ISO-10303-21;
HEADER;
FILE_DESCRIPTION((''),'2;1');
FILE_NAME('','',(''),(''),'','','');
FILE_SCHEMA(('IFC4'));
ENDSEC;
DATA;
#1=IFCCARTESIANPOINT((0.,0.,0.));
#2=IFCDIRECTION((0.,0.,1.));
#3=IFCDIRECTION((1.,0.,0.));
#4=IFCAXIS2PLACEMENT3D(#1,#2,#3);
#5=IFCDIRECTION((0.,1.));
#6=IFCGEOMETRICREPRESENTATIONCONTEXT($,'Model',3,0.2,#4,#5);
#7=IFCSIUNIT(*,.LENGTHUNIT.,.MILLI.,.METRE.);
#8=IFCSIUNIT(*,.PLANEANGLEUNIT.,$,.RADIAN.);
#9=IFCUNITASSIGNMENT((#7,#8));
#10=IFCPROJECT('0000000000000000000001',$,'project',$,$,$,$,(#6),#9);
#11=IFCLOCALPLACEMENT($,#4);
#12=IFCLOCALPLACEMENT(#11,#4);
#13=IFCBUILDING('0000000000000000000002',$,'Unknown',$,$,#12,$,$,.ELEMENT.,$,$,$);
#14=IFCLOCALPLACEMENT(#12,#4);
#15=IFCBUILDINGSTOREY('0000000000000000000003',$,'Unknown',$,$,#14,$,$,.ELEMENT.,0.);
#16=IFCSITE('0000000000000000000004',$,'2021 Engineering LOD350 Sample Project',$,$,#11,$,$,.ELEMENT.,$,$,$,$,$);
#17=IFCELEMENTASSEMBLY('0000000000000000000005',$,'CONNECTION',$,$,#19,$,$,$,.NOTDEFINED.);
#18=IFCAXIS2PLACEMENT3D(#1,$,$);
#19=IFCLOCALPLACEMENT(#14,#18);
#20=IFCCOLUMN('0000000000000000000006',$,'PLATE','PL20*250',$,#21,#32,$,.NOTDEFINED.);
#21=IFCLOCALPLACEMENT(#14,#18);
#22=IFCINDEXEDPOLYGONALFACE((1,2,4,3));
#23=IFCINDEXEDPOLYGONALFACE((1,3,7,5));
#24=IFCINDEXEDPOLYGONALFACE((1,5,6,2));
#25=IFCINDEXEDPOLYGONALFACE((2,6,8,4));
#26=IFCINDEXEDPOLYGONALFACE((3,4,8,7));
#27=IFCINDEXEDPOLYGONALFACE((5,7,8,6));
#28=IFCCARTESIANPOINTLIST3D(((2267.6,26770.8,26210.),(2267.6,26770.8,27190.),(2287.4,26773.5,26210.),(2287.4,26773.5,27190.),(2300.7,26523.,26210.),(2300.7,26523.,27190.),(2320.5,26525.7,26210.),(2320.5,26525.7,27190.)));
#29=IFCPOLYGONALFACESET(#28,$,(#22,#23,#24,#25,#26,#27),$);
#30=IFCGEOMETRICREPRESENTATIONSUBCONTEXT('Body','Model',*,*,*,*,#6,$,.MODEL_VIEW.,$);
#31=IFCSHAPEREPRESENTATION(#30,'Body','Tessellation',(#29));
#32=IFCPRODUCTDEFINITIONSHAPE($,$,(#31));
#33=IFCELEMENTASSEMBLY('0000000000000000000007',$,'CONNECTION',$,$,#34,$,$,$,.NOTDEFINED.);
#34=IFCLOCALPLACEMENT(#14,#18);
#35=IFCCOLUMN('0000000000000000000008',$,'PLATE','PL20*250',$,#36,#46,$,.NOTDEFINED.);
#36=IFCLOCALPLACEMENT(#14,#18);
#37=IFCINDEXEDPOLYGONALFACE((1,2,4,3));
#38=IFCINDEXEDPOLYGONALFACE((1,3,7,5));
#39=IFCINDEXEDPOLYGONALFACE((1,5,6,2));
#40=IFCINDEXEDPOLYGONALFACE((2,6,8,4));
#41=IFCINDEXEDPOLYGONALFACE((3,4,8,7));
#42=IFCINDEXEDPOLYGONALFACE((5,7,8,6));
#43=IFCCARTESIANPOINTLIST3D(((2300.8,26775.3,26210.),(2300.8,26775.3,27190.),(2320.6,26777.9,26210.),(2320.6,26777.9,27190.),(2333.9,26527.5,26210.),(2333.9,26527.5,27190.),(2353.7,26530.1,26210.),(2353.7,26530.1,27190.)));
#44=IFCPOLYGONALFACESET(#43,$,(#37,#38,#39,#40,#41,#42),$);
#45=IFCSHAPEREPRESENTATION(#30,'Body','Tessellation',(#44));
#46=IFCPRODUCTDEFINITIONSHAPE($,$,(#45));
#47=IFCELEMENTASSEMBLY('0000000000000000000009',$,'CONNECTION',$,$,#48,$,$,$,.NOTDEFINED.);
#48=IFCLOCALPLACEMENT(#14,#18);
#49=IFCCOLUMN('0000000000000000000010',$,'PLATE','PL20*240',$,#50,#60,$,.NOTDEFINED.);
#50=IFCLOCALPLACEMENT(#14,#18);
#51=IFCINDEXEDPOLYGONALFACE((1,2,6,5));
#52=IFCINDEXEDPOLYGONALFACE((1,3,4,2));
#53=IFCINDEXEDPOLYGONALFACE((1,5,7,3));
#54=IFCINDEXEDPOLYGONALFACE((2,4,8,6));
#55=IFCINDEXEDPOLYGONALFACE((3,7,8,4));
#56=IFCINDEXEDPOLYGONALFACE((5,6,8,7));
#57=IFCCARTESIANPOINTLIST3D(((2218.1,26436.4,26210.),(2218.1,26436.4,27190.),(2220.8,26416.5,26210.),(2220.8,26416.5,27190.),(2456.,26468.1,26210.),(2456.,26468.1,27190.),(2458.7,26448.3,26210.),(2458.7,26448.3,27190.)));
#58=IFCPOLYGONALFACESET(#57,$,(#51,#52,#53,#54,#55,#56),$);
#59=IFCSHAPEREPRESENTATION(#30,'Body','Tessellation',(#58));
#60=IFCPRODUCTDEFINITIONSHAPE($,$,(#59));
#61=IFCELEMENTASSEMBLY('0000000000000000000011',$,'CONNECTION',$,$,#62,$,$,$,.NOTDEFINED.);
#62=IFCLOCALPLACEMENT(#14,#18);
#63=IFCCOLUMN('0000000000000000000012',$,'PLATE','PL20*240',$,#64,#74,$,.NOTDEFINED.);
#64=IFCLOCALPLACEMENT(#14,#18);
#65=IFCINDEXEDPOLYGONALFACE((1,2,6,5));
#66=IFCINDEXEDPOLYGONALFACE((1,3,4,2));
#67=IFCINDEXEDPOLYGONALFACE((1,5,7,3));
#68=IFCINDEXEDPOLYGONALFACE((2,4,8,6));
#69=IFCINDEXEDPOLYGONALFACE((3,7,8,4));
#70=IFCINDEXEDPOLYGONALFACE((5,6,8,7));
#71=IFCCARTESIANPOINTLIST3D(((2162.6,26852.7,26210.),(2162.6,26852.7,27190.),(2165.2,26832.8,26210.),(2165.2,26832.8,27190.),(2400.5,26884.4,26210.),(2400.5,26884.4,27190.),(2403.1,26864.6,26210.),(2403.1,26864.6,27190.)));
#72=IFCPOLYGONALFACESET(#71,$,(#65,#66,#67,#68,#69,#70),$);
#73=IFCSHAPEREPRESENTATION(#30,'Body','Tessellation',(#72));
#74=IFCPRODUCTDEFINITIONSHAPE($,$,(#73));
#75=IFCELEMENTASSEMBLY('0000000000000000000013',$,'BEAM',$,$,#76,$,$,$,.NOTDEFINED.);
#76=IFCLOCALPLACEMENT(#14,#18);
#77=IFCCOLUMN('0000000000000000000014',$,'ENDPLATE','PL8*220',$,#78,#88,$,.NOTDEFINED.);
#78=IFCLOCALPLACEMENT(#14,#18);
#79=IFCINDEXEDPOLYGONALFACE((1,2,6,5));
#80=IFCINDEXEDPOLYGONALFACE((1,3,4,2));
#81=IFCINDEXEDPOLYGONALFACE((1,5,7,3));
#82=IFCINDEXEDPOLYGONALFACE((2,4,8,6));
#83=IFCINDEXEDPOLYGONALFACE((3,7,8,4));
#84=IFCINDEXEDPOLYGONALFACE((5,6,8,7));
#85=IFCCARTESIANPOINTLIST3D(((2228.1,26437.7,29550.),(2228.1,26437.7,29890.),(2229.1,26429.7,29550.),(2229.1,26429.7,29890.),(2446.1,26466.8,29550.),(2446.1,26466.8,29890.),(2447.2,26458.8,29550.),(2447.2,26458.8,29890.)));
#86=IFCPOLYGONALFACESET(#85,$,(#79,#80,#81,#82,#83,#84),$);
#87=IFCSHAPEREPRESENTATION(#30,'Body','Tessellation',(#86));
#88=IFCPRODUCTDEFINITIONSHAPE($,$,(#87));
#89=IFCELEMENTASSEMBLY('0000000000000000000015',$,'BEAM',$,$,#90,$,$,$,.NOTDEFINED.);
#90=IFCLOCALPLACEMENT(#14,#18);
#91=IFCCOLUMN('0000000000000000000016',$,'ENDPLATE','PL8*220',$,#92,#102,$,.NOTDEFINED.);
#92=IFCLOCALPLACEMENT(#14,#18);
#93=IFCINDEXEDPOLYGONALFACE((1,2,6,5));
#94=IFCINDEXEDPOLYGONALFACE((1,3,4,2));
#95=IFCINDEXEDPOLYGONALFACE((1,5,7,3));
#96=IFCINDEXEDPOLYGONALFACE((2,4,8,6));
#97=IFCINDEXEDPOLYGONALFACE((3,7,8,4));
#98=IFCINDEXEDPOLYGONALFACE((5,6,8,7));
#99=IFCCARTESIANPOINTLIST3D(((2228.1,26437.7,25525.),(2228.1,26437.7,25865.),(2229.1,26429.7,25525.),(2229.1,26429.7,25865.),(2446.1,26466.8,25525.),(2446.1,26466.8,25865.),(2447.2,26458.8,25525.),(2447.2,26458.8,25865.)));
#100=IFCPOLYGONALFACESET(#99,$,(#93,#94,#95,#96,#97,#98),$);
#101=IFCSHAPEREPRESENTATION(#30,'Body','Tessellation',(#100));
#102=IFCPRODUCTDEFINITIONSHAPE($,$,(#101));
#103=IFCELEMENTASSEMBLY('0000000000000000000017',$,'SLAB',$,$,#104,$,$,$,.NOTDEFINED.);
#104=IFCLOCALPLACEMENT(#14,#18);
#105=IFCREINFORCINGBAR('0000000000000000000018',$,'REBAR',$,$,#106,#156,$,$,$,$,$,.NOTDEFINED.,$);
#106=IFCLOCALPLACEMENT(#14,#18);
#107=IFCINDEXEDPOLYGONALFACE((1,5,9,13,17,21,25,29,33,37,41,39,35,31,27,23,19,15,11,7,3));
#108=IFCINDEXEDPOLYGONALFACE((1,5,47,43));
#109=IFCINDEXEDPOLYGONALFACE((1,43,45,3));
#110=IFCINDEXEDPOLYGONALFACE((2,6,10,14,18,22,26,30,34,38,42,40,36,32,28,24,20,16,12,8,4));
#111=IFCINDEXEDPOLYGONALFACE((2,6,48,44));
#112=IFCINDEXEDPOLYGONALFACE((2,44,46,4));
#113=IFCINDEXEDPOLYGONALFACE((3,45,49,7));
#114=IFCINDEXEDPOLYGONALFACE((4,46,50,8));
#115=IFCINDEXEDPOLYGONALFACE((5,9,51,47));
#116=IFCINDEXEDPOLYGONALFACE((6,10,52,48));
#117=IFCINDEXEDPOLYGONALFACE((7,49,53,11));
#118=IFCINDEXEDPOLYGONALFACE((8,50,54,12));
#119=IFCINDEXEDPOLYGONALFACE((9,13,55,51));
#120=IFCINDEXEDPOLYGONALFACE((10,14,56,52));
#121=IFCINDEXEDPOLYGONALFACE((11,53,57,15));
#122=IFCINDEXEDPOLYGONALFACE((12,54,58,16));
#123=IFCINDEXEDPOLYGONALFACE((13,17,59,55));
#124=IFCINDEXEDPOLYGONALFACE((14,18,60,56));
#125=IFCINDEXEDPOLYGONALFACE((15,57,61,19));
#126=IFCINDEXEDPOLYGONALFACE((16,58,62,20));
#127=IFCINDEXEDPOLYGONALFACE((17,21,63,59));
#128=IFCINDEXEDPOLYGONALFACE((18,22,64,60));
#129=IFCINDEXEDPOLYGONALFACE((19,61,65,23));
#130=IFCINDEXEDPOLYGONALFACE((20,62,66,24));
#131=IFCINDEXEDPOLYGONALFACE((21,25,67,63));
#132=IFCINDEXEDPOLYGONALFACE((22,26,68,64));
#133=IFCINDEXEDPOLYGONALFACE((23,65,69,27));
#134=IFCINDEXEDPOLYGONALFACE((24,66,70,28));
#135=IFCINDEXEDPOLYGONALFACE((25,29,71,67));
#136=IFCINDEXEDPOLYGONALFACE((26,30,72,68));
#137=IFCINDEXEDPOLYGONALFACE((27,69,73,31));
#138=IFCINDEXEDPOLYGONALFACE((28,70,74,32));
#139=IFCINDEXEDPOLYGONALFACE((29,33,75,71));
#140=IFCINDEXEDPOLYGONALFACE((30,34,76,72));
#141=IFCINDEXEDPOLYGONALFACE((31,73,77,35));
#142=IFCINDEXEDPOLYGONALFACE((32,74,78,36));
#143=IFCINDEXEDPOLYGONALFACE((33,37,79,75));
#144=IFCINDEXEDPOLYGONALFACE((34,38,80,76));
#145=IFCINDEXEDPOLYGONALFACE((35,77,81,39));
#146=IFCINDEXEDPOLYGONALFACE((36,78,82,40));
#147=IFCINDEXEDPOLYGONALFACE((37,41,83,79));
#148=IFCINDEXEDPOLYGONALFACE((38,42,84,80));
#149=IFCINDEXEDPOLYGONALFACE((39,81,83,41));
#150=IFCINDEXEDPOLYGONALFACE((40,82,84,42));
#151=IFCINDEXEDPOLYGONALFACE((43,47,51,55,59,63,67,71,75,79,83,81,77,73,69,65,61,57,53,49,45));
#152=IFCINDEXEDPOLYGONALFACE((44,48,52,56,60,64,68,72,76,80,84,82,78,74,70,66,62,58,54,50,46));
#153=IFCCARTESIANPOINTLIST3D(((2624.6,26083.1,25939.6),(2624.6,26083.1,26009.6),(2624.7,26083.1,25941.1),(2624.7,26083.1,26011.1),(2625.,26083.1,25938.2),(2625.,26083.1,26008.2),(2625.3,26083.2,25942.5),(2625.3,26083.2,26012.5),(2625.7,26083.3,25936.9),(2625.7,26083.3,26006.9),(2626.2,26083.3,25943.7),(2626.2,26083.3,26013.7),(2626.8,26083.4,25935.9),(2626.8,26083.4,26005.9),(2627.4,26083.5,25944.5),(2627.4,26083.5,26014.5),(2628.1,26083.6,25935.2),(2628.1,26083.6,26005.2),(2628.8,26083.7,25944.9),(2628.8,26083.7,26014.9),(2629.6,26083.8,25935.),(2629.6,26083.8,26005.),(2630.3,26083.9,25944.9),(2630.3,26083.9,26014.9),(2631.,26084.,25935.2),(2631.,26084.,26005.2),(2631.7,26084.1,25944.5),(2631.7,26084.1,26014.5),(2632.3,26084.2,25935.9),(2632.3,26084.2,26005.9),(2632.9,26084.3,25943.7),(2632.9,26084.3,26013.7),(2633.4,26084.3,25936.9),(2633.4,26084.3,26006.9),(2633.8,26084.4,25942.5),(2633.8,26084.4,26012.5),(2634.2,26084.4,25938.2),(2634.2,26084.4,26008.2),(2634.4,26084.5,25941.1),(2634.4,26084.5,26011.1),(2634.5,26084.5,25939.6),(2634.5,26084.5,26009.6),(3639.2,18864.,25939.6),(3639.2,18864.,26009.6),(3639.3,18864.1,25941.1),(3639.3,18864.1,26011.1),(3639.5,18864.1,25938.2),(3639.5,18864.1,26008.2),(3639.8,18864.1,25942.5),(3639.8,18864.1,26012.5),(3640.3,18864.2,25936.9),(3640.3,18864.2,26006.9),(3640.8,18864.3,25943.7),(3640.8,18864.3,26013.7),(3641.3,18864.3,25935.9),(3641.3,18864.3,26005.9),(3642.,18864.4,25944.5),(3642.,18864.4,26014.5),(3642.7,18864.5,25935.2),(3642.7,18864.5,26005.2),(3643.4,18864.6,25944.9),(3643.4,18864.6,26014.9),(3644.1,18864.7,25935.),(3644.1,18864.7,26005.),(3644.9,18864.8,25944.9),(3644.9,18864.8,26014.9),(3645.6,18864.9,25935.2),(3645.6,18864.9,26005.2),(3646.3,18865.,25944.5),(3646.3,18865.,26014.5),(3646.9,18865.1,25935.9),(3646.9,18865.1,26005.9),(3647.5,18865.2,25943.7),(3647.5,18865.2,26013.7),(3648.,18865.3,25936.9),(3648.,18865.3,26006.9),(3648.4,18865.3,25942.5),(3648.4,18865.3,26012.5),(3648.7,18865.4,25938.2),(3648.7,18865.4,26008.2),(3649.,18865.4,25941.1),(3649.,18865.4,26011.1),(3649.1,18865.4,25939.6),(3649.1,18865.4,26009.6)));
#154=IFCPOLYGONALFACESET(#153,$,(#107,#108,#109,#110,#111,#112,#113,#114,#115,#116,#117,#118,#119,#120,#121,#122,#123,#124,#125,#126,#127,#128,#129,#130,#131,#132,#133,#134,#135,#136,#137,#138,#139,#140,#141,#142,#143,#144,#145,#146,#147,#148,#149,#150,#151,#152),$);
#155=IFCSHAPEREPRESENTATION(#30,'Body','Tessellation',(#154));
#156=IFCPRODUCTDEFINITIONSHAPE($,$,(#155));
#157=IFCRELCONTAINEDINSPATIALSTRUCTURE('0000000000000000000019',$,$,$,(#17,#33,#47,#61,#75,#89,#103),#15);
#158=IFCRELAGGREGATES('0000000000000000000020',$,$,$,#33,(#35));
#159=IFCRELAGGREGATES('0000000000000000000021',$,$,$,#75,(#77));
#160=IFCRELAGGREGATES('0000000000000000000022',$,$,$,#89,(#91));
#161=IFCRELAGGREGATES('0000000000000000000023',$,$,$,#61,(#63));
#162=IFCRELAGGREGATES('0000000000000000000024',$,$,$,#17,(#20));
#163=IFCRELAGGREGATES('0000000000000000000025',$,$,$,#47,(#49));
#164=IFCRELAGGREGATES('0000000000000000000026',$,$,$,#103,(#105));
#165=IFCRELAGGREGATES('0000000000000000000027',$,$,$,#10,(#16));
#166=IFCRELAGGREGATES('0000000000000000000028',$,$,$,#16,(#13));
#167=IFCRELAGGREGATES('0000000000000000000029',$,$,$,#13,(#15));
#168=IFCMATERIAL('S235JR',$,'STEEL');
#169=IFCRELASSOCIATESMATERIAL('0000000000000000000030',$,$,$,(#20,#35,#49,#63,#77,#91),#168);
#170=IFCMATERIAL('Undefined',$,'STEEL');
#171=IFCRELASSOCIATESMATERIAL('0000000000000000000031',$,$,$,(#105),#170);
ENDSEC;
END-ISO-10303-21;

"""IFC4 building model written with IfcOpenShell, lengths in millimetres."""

from ifc_helpers import new_model, entity, si_unit, direction, frame, origin_with_axes, place, context, subcontext, project, spatial, line, indexed_curve, outline, extrude, source, transform, mapped, material, element, aggregate, save


model = new_model("IFC4")

# Units and contexts
model_context = context("Model", 3, precision=0.2, world=origin_with_axes(), true_north=direction((0.0, 1.0)))
body_context = subcontext(model_context, "Body", "Model", "MODEL_VIEW")
ifc_project = project(units=[si_unit("LENGTHUNIT", "METRE", prefix="MILLI"), si_unit("PLANEANGLEUNIT", "RADIAN")], contexts=[model_context])

# Site, building, storey
site_placement = place(None, origin_with_axes())
site = spatial("IfcSite", under=ifc_project, at=site_placement, Name="2021 Engineering LOD350 Sample Project", CompositionType="ELEMENT")
building_placement = place(site_placement, origin_with_axes())
building = spatial("IfcBuilding", under=site, at=building_placement, Name="Unknown", CompositionType="ELEMENT")
storey_placement = place(building_placement, origin_with_axes())
storey = spatial("IfcBuildingStorey", under=building, at=storey_placement, Name="Unknown", CompositionType="ELEMENT", Elevation=0.0)

# Shared definitions
ifc_material_1 = material(Name="S235JR", Category="STEEL")

# Element assemblies, columns
assembly_1_placement = place(storey_placement, frame((2294.0, 26648.3, 26210.0), z_axis=(-0.991216, -0.132256, 0.0), x_axis=(0.0, 0.0, 1.0)))
assembly_1 = element("IfcElementAssembly", 1, at=assembly_1_placement, inside=storey, Name="CONNECTION", PredefinedType="NOTDEFINED")
column_1_placement = place(assembly_1_placement, origin_with_axes())
column_1 = element("IfcColumn", 2, at=column_1_placement, material=ifc_material_1, Name="PLATE", Description="PL20*250", PredefinedType="NOTDEFINED", context=body_context, shape_type="SolidModel", body=[
    extrude(outline(indexed_curve([(-10.0, -125.0), (10.0, -125.0), (10.0, 125.0), (-10.0, 125.0)], segments=[line(1, 2, 3, 4, 1)])), frame((0.0, 0.0, 0.0), z_axis=(-1.0, 0.0, 0.0), x_axis=(0.0, 0.0, 1.0)), (0.0, 0.0, -1.0), 980.0),
])
assembly_2_placement = place(storey_placement, frame((2327.2, 26652.7, 26210.0), z_axis=(-0.991216, -0.132256, 0.0), x_axis=(0.0, 0.0, 1.0)))
assembly_2 = element("IfcElementAssembly", 3, at=assembly_2_placement, inside=storey, Name="CONNECTION", PredefinedType="NOTDEFINED")
column_2_placement = place(assembly_2_placement, origin_with_axes())
column_2 = element("IfcColumn", 4, at=column_2_placement, material=ifc_material_1, Name="PLATE", Description="PL20*250", PredefinedType="NOTDEFINED", context=body_context, shape_type="SolidModel", body=[
    extrude(outline(indexed_curve([(-10.0, -125.0), (10.0, -125.0), (10.0, 125.0), (-10.0, 125.0)], segments=[line(1, 2, 3, 4, 1)])), frame((0.0, 0.0, 0.0), z_axis=(-1.0, 0.0, 0.0), x_axis=(0.0, 0.0, 1.0)), (0.0, 0.0, -1.0), 980.0),
])
aggregate(assembly_2, [column_2])
assembly_3_placement = place(storey_placement, frame((2338.4, 26442.3, 26210.0), z_axis=(0.132256, -0.991216, 0.0), x_axis=(0.0, 0.0, 1.0)))
assembly_3 = element("IfcElementAssembly", 5, at=assembly_3_placement, inside=storey, Name="CONNECTION", PredefinedType="NOTDEFINED")
column_3_placement = place(assembly_3_placement, origin_with_axes())
column_3 = element("IfcColumn", 6, at=column_3_placement, material=ifc_material_1, Name="PLATE", Description="PL20*240", PredefinedType="NOTDEFINED", context=body_context, shape_type="SolidModel", body=[
    extrude(outline(indexed_curve([(-10.0, -120.0), (10.0, -120.0), (10.0, 120.0), (-10.0, 120.0)], segments=[line(1, 2, 3, 4, 1)])), frame((0.0, 0.0, 0.0), z_axis=(-1.0, 0.0, 0.0), x_axis=(0.0, 0.0, 1.0)), (0.0, 0.0, -1.0), 980.0),
])
assembly_4_placement = place(storey_placement, frame((2282.9, 26858.6, 26210.0), z_axis=(-0.132256, 0.991216, 0.0), x_axis=(0.0, 0.0, 1.0)))
assembly_4 = element("IfcElementAssembly", 7, at=assembly_4_placement, inside=storey, Name="CONNECTION", PredefinedType="NOTDEFINED")
column_4_placement = place(assembly_4_placement, origin_with_axes())
column_4 = element("IfcColumn", 8, at=column_4_placement, material=ifc_material_1, Name="PLATE", Description="PL20*240", PredefinedType="NOTDEFINED", context=body_context, shape_type="SolidModel", body=[
    extrude(outline(indexed_curve([(-10.0, -120.0), (10.0, -120.0), (10.0, 120.0), (-10.0, 120.0)], segments=[line(1, 2, 3, 4, 1)])), frame((0.0, 0.0, 0.0), z_axis=(-1.0, 0.0, 0.0), x_axis=(0.0, 0.0, 1.0)), (0.0, 0.0, -1.0), 980.0),
])
assembly_5_placement = place(storey_placement, frame((2462.8, 25510.0, 29720.0), z_axis=(0.991216, 0.132255, 0.0), x_axis=(-0.132255, 0.991216, 0.0)))
assembly_5 = element("IfcElementAssembly", 9, at=assembly_5_placement, inside=storey, Name="BEAM", PredefinedType="NOTDEFINED")
column_5_placement = place(assembly_5_placement, frame((946.6, -170.0, 0.0), z_axis=(-1.0, 0.0, 0.000001), x_axis=(0.0, 1.0, 0.0)))
column_5 = element("IfcColumn", 10, at=column_5_placement, material=ifc_material_1, Name="ENDPLATE", Description="PL8*220", PredefinedType="NOTDEFINED", context=body_context, shape_type="SolidModel", body=[
    extrude(outline(indexed_curve([(-4.0, -110.0), (4.0, -110.0), (4.0, 110.0), (-4.0, 110.0)], segments=[line(1, 2, 3, 4, 1)])), frame((0.0, 0.0, 0.0), z_axis=(-1.0, 0.0, 0.0), x_axis=(0.0, 0.0, 1.0)), (0.0, 0.0, -1.0), 340.0),
])
aggregate(assembly_5, [column_5])
assembly_6_placement = place(storey_placement, frame((2462.8, 25510.0, 25695.0), z_axis=(0.991216, 0.132255, 0.0), x_axis=(-0.132255, 0.991216, 0.0)))
assembly_6 = element("IfcElementAssembly", 11, at=assembly_6_placement, inside=storey, Name="BEAM", PredefinedType="NOTDEFINED")
column_6_placement = place(assembly_6_placement, frame((946.6, -170.0, 0.0), z_axis=(-1.0, 0.0, 0.000001), x_axis=(0.0, 1.0, 0.0)))
column_6 = element("IfcColumn", 12, at=column_6_placement, material=ifc_material_1, Name="ENDPLATE", Description="PL8*220", PredefinedType="NOTDEFINED", context=body_context, shape_type="SolidModel", body=[
    extrude(outline(indexed_curve([(-4.0, -110.0), (4.0, -110.0), (4.0, 110.0), (-4.0, 110.0)], segments=[line(1, 2, 3, 4, 1)])), frame((0.0, 0.0, 0.0), z_axis=(-1.0, 0.0, 0.0), x_axis=(0.0, 0.0, 1.0)), (0.0, 0.0, -1.0), 340.0),
])

aggregate(assembly_6, [column_6])

# Element assembly, reinforcing bar
assembly_7_placement = place(storey_placement, frame((0.0, 19194.4, 25975.0), z_axis=(0.0, 0.0, 1.0), x_axis=(0.0, -1.0, 0.0)))
assembly_7 = element("IfcElementAssembly", 13, at=assembly_7_placement, inside=storey, Name="SLAB", PredefinedType="NOTDEFINED")
ifc_material_2 = material(Name="Undefined", Category="STEEL")
shared_shape_1 = source(origin_with_axes(), body_context, "Body", "AdvancedSweptSolid", [
    entity("IfcSweptDiskSolid", entity("IfcIndexedPolyCurve", entity("IfcCartesianPointList3D", [[0.0, 0.0, 0.0], [7290.0, 0.0, 0.0]]), [entity("IfcLineIndex", [1, 2])]), 5.0),
])
reinforcing_bar_1_placement = place(assembly_7_placement, frame((-6889.4, 2629.6, -35.0), z_axis=(0.0, 0.0, -1.0), x_axis=(0.990268, 0.139173, 0.0)))
reinforcing_bar_1 = element("IfcReinforcingBar", 14, at=reinforcing_bar_1_placement, material=ifc_material_2, Name="REBAR", PredefinedType="NOTDEFINED", context=body_context, shape_type="MappedRepresentation", body=[
    mapped(shared_shape_1, transform((0.0, 0.0, 0.0))),
    mapped(shared_shape_1, transform((0.0, 0.0, -70.0))),
])

aggregate(assembly_4, [column_4])
aggregate(assembly_1, [column_1])
aggregate(assembly_3, [column_3])

aggregate(assembly_7, [reinforcing_bar_1])

save(model, "model.ifc")
